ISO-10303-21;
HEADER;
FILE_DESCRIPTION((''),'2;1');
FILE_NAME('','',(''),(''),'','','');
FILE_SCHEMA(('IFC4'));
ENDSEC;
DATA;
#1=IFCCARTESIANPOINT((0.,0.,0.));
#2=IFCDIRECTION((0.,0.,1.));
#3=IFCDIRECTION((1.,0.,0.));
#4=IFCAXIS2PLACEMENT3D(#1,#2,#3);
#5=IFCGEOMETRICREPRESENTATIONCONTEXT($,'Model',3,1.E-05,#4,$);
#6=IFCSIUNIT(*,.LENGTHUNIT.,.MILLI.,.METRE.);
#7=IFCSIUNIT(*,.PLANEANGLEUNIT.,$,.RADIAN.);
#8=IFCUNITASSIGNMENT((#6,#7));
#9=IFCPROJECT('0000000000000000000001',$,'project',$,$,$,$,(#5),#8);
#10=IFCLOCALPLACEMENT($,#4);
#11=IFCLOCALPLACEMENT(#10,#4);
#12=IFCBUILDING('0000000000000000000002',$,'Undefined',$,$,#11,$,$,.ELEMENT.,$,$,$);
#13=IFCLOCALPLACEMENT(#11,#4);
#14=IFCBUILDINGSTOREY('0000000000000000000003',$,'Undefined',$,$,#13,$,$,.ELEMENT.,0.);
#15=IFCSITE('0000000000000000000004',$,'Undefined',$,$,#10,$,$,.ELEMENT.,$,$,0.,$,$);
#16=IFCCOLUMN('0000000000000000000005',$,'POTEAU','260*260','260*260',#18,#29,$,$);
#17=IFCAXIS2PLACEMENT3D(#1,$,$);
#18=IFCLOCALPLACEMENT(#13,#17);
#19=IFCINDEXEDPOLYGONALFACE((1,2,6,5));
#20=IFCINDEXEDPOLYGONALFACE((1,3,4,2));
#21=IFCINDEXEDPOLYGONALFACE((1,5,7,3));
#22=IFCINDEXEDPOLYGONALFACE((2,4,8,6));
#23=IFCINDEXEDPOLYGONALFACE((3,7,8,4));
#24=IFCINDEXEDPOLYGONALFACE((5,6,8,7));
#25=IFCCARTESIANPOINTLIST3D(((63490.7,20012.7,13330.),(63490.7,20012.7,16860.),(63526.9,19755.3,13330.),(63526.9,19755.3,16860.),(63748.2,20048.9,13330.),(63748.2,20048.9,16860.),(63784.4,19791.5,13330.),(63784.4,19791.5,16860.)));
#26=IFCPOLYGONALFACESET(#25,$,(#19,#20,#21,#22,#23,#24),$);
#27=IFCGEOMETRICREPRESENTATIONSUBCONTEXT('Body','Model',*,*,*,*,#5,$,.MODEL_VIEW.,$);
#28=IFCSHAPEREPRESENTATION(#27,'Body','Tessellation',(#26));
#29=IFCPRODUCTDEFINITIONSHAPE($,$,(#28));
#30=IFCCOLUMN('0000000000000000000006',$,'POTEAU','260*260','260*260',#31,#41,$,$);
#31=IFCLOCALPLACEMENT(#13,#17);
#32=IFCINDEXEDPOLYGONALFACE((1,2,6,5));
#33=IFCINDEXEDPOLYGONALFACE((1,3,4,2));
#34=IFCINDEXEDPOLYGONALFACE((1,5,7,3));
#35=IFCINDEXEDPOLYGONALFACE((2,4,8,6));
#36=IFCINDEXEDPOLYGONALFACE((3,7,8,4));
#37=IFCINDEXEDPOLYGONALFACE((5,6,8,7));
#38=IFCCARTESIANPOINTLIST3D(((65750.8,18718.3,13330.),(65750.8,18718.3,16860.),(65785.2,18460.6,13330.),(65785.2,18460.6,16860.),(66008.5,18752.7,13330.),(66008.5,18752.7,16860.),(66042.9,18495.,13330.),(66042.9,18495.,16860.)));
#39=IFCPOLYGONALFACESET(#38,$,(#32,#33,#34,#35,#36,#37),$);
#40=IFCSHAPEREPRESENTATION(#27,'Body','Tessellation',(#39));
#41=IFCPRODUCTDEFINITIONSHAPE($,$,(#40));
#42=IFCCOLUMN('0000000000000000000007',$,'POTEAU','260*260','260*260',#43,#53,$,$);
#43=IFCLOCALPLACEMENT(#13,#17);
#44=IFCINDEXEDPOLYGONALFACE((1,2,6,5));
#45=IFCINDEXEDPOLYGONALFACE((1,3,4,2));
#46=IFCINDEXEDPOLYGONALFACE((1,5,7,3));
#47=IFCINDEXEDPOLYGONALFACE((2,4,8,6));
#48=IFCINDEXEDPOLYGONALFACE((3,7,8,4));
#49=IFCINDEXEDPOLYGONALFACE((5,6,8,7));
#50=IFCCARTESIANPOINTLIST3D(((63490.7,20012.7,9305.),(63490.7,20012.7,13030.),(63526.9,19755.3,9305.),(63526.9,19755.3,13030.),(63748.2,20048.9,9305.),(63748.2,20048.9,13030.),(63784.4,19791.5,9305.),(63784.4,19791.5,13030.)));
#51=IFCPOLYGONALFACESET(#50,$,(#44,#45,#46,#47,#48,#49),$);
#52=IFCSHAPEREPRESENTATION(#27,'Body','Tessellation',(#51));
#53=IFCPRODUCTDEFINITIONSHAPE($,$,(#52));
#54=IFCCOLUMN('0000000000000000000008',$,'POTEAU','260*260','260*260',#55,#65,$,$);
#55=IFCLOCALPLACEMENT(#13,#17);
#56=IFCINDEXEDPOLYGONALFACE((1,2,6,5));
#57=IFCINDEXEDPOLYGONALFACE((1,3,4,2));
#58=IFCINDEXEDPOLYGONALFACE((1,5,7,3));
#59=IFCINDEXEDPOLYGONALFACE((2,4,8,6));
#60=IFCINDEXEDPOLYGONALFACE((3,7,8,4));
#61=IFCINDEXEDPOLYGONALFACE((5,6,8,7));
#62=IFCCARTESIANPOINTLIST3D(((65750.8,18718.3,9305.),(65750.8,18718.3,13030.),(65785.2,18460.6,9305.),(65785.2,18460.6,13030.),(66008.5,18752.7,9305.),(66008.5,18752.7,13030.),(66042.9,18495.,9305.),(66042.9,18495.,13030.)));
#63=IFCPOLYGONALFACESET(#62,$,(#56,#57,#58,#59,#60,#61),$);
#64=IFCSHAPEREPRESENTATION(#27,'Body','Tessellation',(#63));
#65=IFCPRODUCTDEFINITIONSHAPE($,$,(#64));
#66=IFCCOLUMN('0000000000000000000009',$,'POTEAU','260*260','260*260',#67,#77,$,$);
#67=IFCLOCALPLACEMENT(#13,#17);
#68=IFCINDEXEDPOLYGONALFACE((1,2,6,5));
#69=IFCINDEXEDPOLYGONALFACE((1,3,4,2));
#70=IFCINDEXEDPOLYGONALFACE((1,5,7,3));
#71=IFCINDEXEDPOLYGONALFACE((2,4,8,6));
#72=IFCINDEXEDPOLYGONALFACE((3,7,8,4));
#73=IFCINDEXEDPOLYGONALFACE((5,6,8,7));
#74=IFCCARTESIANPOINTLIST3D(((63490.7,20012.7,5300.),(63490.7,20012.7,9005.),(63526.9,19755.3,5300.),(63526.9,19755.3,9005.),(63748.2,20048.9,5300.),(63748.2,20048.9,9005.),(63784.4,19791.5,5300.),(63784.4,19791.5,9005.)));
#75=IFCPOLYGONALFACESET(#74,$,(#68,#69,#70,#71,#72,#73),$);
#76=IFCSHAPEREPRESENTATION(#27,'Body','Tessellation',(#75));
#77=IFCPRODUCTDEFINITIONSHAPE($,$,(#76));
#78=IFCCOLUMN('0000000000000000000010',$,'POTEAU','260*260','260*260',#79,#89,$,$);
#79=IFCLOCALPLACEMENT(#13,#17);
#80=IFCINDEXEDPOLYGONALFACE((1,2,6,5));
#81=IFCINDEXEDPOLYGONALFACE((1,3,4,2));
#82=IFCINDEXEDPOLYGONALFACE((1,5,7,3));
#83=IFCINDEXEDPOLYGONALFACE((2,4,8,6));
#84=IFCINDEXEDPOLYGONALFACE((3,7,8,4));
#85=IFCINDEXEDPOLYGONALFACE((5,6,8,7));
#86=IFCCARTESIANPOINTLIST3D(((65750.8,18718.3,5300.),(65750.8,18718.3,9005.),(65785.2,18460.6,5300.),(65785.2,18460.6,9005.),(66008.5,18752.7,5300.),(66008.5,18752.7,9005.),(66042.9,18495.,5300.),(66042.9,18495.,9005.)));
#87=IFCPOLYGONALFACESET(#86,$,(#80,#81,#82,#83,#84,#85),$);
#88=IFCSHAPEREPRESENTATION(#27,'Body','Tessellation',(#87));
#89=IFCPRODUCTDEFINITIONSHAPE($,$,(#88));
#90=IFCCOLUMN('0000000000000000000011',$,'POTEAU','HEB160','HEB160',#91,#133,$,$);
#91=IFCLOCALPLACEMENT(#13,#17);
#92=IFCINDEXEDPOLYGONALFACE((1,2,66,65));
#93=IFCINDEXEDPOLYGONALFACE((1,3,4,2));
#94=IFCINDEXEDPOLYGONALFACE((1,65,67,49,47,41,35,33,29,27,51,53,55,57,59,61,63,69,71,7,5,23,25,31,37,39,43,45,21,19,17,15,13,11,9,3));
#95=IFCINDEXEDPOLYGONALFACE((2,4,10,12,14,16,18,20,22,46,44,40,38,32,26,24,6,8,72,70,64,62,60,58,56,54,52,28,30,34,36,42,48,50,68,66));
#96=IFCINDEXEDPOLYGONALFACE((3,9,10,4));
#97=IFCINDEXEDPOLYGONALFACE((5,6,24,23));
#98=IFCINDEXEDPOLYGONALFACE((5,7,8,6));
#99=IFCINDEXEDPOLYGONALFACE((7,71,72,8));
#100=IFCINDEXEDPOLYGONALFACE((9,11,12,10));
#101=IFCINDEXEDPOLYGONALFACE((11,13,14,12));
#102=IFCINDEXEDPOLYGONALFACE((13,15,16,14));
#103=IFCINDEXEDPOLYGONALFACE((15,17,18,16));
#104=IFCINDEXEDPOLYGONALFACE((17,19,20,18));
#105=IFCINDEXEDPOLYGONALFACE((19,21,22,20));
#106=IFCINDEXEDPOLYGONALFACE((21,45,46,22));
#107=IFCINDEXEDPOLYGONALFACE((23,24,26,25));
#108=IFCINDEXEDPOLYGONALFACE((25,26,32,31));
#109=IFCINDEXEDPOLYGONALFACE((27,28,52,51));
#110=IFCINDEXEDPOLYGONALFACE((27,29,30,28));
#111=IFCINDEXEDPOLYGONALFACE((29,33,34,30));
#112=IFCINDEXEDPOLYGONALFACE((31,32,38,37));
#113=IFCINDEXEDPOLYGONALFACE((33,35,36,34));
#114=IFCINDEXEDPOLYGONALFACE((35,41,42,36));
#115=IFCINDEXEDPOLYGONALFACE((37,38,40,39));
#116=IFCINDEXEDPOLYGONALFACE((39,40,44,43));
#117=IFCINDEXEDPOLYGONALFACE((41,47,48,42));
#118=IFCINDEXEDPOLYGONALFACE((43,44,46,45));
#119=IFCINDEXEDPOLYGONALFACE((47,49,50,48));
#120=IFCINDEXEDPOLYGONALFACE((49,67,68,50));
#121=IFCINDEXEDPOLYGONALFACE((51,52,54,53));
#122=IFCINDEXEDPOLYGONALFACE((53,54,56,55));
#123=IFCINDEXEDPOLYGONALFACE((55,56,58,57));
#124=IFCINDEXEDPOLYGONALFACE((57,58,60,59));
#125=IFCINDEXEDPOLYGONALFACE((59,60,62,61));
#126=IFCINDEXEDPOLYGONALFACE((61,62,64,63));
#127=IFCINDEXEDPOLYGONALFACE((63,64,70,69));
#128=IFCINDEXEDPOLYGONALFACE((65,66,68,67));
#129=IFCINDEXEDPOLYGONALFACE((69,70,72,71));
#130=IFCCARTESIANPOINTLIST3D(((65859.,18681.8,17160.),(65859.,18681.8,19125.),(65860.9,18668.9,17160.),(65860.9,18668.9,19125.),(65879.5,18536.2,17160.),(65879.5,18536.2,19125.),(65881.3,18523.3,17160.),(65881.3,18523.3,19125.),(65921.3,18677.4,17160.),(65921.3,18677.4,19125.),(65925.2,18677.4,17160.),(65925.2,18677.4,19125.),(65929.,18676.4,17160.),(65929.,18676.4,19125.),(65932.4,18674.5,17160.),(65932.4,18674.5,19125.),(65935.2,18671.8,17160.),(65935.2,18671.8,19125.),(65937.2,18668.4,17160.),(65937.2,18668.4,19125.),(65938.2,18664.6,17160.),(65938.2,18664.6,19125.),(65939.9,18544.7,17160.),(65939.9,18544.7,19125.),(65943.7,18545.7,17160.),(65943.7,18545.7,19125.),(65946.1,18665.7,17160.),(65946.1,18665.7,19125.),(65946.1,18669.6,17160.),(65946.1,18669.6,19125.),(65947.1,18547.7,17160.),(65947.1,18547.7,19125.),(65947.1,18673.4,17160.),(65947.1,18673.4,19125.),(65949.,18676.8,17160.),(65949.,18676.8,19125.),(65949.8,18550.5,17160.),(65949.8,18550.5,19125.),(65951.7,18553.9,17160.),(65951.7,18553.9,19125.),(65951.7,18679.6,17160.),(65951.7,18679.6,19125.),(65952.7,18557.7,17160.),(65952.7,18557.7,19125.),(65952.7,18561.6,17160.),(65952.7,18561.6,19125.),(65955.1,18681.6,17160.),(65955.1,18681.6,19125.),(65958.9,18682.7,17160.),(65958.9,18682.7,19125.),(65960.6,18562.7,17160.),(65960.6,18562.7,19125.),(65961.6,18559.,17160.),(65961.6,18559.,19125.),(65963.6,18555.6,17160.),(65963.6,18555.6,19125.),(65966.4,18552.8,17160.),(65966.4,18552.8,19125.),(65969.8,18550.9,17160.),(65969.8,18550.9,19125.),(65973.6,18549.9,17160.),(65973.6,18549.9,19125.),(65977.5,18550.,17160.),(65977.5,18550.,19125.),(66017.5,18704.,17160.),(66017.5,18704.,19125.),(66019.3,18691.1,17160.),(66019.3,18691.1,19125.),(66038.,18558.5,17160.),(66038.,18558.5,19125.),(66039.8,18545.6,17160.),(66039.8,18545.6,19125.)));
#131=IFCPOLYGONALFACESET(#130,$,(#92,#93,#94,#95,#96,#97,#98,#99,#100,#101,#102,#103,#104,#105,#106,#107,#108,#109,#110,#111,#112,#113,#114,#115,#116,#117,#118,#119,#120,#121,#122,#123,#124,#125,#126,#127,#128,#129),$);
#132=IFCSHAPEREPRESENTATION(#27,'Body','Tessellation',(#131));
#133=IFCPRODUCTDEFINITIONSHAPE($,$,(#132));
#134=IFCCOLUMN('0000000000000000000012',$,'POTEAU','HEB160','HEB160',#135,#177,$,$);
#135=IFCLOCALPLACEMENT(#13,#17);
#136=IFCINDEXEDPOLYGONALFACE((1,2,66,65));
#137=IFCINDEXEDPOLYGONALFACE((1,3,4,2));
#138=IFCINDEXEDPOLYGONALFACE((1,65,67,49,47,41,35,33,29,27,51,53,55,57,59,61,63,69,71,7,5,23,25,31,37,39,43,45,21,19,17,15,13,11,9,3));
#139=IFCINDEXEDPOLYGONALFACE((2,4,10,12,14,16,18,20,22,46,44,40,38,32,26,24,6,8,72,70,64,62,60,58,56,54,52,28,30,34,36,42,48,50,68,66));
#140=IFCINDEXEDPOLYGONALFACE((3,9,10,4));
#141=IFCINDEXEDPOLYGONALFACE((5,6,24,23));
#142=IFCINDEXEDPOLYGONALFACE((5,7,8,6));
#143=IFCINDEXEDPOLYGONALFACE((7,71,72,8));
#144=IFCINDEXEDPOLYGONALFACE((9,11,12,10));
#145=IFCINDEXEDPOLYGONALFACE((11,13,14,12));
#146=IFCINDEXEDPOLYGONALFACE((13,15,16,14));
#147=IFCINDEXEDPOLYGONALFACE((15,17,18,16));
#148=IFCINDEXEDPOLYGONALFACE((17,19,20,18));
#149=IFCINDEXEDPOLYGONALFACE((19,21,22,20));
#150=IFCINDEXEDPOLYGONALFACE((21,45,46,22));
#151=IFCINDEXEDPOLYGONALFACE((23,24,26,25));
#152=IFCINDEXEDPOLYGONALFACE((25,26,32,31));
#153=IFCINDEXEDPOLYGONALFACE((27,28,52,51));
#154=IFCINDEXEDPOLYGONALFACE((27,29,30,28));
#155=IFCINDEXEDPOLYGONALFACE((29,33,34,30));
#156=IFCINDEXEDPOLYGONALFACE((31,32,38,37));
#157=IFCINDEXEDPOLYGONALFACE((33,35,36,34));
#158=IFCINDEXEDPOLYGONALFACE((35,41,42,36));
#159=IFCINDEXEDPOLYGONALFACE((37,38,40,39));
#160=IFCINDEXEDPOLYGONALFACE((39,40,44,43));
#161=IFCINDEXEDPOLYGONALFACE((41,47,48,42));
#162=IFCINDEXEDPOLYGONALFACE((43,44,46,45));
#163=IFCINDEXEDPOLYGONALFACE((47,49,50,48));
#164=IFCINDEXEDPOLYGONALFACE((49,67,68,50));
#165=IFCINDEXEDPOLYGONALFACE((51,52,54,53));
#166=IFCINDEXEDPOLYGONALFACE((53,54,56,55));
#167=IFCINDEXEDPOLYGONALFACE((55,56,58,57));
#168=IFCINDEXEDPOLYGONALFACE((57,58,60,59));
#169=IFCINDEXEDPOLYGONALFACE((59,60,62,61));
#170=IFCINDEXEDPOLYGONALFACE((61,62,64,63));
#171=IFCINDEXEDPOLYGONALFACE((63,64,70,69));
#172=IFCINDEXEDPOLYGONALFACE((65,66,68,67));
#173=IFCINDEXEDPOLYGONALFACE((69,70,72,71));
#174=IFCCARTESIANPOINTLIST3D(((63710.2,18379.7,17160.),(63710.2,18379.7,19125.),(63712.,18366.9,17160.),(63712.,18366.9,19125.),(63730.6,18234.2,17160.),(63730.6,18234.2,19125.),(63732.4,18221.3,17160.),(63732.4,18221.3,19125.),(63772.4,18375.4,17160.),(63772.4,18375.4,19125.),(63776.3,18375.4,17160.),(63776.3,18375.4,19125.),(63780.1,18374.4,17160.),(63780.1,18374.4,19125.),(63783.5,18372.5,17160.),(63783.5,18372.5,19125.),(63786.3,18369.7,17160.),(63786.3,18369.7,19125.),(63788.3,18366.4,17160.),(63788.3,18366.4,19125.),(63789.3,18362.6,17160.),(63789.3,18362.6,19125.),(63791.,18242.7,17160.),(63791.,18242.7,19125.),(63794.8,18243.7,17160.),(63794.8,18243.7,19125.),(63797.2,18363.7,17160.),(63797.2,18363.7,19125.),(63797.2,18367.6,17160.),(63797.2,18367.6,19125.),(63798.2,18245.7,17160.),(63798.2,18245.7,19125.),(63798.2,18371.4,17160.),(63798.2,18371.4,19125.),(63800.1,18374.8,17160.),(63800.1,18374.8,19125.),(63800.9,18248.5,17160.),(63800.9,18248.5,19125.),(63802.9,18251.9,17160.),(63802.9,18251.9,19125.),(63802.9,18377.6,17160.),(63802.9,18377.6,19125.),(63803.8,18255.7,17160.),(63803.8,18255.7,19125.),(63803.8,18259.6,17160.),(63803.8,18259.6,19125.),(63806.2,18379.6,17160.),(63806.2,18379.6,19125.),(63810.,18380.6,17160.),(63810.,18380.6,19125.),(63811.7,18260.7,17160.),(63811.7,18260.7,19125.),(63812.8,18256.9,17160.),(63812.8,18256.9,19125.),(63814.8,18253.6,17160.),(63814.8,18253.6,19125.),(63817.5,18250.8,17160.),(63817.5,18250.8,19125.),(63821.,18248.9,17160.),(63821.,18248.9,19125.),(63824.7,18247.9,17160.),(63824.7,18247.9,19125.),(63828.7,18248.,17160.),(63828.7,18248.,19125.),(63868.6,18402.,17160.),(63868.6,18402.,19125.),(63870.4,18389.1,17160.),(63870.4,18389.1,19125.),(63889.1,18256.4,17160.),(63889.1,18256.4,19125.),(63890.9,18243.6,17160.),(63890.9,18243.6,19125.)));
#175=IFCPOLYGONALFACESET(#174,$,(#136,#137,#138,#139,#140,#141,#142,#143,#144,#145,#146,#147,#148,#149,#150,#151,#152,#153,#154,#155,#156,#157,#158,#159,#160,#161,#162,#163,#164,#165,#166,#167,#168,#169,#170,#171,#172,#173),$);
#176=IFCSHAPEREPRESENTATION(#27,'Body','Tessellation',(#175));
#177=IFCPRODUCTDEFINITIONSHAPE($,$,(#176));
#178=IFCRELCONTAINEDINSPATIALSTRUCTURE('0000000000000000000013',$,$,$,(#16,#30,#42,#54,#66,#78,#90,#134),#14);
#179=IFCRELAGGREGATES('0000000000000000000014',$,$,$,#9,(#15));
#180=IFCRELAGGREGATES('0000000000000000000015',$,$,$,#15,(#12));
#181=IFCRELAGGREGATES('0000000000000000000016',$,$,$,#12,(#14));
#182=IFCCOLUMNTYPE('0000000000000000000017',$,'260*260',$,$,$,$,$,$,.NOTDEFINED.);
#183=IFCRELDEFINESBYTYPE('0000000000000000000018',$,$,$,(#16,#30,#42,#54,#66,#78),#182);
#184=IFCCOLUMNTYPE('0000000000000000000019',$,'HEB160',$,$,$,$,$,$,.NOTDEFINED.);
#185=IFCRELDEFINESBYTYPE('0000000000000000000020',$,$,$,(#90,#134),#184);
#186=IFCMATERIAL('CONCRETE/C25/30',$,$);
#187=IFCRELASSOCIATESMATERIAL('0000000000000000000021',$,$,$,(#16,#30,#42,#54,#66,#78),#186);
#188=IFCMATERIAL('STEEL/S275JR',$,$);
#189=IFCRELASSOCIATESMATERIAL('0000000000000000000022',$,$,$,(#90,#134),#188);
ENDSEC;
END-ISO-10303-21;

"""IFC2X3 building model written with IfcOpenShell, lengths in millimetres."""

from ifc_helpers import new_model, si_unit, frame, origin_with_axes, origin_2d_with_axis, place, context, subcontext, project, spatial, rectangle, i_section, extrude, material, type_object, element, save


model = new_model("IFC2X3")

# Units and contexts
model_context = context("Model", 3, precision=1e-05, world=origin_with_axes())
body_context = subcontext(model_context, "Body", "Model", "MODEL_VIEW")
ifc_project = project(units=[si_unit("LENGTHUNIT", "METRE", prefix="MILLI"), si_unit("PLANEANGLEUNIT", "RADIAN")], contexts=[model_context])

# Site, building, storey
site_placement = place(None, origin_with_axes())
site = spatial("IfcSite", under=ifc_project, at=site_placement, Name="Undefined", CompositionType="ELEMENT", RefElevation=0.0)
building_placement = place(site_placement, origin_with_axes())
building = spatial("IfcBuilding", under=site, at=building_placement, Name="Undefined", CompositionType="ELEMENT")
storey_placement = place(building_placement, origin_with_axes())
storey = spatial("IfcBuildingStorey", under=building, at=storey_placement, Name="Undefined", CompositionType="ELEMENT", Elevation=0.0)

# Columns
ifc_material_1 = material(Name="CONCRETE/C25/30")
column_type_1 = type_object("IfcColumnType", Name="260*260", PredefinedType="NOTDEFINED")
column_1_placement = place(storey_placement, frame((63637.6, 19902.1, 13330.0), z_axis=(0.0, 0.0, 1.0), x_axis=(1.0, 0.0, 0.0)))
element("IfcColumn", 1, at=column_1_placement, inside=storey, type_object=column_type_1, material=ifc_material_1, Name="POTEAU", Description="260*260", ObjectType="260*260", context=body_context, shape_type="SweptSolid", body=[
    extrude(rectangle(XDim=260.0, YDim=260.0, at=origin_2d_with_axis()), frame((0.0, 0.0, 3530.0), z_axis=(0.0, 0.0, -1.0), x_axis=(-0.139177, 0.990267, 0.0)), (0.0, 0.0, 1.0), 3530.0),
])
column_2_placement = place(storey_placement, frame((65896.8, 18606.7, 13330.0), z_axis=(0.0, 0.0, 1.0), x_axis=(1.0, 0.0, 0.0)))
element("IfcColumn", 2, at=column_2_placement, inside=storey, type_object=column_type_1, material=ifc_material_1, Name="POTEAU", Description="260*260", ObjectType="260*260", context=body_context, shape_type="SweptSolid", body=[
    extrude(rectangle(XDim=260.0, YDim=260.0, at=origin_2d_with_axis()), frame((0.0, 0.0, 3530.0), z_axis=(0.0, 0.0, -1.0), x_axis=(0.132256, -0.991216, 0.0)), (0.0, 0.0, 1.0), 3530.0),
])
column_3_placement = place(storey_placement, frame((63637.6, 19902.1, 9305.0), z_axis=(0.0, 0.0, 1.0), x_axis=(1.0, 0.0, 0.0)))
element("IfcColumn", 3, at=column_3_placement, inside=storey, type_object=column_type_1, material=ifc_material_1, Name="POTEAU", Description="260*260", ObjectType="260*260", context=body_context, shape_type="SweptSolid", body=[
    extrude(rectangle(XDim=260.0, YDim=260.0, at=origin_2d_with_axis()), frame((0.0, 0.0, 3725.0), z_axis=(0.0, 0.0, -1.0), x_axis=(-0.139177, 0.990267, 0.0)), (0.0, 0.0, 1.0), 3725.0),
])
column_4_placement = place(storey_placement, frame((65896.8, 18606.7, 9305.0), z_axis=(0.0, 0.0, 1.0), x_axis=(1.0, 0.0, 0.0)))
element("IfcColumn", 4, at=column_4_placement, inside=storey, type_object=column_type_1, material=ifc_material_1, Name="POTEAU", Description="260*260", ObjectType="260*260", context=body_context, shape_type="SweptSolid", body=[
    extrude(rectangle(XDim=260.0, YDim=260.0, at=origin_2d_with_axis()), frame((0.0, 0.0, 3725.0), z_axis=(0.0, 0.0, -1.0), x_axis=(0.132256, -0.991216, 0.0)), (0.0, 0.0, 1.0), 3725.0),
])
column_5_placement = place(storey_placement, frame((63637.6, 19902.1, 5300.0), z_axis=(0.0, 0.0, 1.0), x_axis=(1.0, 0.0, 0.0)))
element("IfcColumn", 5, at=column_5_placement, inside=storey, type_object=column_type_1, material=ifc_material_1, Name="POTEAU", Description="260*260", ObjectType="260*260", context=body_context, shape_type="SweptSolid", body=[
    extrude(rectangle(XDim=260.0, YDim=260.0, at=origin_2d_with_axis()), frame((0.0, 0.0, 3705.0), z_axis=(0.0, 0.0, -1.0), x_axis=(-0.139177, 0.990267, 0.0)), (0.0, 0.0, 1.0), 3705.0),
])
column_6_placement = place(storey_placement, frame((65896.8, 18606.7, 5300.0), z_axis=(0.0, 0.0, 1.0), x_axis=(1.0, 0.0, 0.0)))
element("IfcColumn", 6, at=column_6_placement, inside=storey, type_object=column_type_1, material=ifc_material_1, Name="POTEAU", Description="260*260", ObjectType="260*260", context=body_context, shape_type="SweptSolid", body=[
    extrude(rectangle(XDim=260.0, YDim=260.0, at=origin_2d_with_axis()), frame((0.0, 0.0, 3705.0), z_axis=(0.0, 0.0, -1.0), x_axis=(0.132256, -0.991216, 0.0)), (0.0, 0.0, 1.0), 3705.0),
])
ifc_material_2 = material(Name="STEEL/S275JR")
column_type_2 = type_object("IfcColumnType", Name="HEB160", PredefinedType="NOTDEFINED")
for number, where, z_axis, x_axis, name in (
    (7, (65949.4, 18613.7, 17160.0), (0.0, 0.0, 1.0), (1.0, 0.0, 0.0), "POTEAU"),
    (8, (63800.5, 18311.7, 17160.0), (0.0, 0.0, 1.0), (1.0, 0.0, 0.0), "POTEAU"),
):
    element("IfcColumn", number, at=place(storey_placement, frame(where, z_axis=z_axis, x_axis=x_axis)), inside=storey, type_object=column_type_2, material=ifc_material_2, Name=name, Description="HEB160", ObjectType="HEB160", context=body_context, shape_type="SweptSolid", body=[
        extrude(i_section(OverallWidth=160.0, OverallDepth=160.0, WebThickness=8.0, FlangeThickness=13.0, FilletRadius=15.0, at=origin_2d_with_axis()), frame((0.0, 0.0, 1965.0), z_axis=(0.0, 0.0, -1.0), x_axis=(-0.990268, -0.139173, 0.0)), (0.0, 0.0, 1.0), 1965.0),
    ])

save(model, "model.ifc")
